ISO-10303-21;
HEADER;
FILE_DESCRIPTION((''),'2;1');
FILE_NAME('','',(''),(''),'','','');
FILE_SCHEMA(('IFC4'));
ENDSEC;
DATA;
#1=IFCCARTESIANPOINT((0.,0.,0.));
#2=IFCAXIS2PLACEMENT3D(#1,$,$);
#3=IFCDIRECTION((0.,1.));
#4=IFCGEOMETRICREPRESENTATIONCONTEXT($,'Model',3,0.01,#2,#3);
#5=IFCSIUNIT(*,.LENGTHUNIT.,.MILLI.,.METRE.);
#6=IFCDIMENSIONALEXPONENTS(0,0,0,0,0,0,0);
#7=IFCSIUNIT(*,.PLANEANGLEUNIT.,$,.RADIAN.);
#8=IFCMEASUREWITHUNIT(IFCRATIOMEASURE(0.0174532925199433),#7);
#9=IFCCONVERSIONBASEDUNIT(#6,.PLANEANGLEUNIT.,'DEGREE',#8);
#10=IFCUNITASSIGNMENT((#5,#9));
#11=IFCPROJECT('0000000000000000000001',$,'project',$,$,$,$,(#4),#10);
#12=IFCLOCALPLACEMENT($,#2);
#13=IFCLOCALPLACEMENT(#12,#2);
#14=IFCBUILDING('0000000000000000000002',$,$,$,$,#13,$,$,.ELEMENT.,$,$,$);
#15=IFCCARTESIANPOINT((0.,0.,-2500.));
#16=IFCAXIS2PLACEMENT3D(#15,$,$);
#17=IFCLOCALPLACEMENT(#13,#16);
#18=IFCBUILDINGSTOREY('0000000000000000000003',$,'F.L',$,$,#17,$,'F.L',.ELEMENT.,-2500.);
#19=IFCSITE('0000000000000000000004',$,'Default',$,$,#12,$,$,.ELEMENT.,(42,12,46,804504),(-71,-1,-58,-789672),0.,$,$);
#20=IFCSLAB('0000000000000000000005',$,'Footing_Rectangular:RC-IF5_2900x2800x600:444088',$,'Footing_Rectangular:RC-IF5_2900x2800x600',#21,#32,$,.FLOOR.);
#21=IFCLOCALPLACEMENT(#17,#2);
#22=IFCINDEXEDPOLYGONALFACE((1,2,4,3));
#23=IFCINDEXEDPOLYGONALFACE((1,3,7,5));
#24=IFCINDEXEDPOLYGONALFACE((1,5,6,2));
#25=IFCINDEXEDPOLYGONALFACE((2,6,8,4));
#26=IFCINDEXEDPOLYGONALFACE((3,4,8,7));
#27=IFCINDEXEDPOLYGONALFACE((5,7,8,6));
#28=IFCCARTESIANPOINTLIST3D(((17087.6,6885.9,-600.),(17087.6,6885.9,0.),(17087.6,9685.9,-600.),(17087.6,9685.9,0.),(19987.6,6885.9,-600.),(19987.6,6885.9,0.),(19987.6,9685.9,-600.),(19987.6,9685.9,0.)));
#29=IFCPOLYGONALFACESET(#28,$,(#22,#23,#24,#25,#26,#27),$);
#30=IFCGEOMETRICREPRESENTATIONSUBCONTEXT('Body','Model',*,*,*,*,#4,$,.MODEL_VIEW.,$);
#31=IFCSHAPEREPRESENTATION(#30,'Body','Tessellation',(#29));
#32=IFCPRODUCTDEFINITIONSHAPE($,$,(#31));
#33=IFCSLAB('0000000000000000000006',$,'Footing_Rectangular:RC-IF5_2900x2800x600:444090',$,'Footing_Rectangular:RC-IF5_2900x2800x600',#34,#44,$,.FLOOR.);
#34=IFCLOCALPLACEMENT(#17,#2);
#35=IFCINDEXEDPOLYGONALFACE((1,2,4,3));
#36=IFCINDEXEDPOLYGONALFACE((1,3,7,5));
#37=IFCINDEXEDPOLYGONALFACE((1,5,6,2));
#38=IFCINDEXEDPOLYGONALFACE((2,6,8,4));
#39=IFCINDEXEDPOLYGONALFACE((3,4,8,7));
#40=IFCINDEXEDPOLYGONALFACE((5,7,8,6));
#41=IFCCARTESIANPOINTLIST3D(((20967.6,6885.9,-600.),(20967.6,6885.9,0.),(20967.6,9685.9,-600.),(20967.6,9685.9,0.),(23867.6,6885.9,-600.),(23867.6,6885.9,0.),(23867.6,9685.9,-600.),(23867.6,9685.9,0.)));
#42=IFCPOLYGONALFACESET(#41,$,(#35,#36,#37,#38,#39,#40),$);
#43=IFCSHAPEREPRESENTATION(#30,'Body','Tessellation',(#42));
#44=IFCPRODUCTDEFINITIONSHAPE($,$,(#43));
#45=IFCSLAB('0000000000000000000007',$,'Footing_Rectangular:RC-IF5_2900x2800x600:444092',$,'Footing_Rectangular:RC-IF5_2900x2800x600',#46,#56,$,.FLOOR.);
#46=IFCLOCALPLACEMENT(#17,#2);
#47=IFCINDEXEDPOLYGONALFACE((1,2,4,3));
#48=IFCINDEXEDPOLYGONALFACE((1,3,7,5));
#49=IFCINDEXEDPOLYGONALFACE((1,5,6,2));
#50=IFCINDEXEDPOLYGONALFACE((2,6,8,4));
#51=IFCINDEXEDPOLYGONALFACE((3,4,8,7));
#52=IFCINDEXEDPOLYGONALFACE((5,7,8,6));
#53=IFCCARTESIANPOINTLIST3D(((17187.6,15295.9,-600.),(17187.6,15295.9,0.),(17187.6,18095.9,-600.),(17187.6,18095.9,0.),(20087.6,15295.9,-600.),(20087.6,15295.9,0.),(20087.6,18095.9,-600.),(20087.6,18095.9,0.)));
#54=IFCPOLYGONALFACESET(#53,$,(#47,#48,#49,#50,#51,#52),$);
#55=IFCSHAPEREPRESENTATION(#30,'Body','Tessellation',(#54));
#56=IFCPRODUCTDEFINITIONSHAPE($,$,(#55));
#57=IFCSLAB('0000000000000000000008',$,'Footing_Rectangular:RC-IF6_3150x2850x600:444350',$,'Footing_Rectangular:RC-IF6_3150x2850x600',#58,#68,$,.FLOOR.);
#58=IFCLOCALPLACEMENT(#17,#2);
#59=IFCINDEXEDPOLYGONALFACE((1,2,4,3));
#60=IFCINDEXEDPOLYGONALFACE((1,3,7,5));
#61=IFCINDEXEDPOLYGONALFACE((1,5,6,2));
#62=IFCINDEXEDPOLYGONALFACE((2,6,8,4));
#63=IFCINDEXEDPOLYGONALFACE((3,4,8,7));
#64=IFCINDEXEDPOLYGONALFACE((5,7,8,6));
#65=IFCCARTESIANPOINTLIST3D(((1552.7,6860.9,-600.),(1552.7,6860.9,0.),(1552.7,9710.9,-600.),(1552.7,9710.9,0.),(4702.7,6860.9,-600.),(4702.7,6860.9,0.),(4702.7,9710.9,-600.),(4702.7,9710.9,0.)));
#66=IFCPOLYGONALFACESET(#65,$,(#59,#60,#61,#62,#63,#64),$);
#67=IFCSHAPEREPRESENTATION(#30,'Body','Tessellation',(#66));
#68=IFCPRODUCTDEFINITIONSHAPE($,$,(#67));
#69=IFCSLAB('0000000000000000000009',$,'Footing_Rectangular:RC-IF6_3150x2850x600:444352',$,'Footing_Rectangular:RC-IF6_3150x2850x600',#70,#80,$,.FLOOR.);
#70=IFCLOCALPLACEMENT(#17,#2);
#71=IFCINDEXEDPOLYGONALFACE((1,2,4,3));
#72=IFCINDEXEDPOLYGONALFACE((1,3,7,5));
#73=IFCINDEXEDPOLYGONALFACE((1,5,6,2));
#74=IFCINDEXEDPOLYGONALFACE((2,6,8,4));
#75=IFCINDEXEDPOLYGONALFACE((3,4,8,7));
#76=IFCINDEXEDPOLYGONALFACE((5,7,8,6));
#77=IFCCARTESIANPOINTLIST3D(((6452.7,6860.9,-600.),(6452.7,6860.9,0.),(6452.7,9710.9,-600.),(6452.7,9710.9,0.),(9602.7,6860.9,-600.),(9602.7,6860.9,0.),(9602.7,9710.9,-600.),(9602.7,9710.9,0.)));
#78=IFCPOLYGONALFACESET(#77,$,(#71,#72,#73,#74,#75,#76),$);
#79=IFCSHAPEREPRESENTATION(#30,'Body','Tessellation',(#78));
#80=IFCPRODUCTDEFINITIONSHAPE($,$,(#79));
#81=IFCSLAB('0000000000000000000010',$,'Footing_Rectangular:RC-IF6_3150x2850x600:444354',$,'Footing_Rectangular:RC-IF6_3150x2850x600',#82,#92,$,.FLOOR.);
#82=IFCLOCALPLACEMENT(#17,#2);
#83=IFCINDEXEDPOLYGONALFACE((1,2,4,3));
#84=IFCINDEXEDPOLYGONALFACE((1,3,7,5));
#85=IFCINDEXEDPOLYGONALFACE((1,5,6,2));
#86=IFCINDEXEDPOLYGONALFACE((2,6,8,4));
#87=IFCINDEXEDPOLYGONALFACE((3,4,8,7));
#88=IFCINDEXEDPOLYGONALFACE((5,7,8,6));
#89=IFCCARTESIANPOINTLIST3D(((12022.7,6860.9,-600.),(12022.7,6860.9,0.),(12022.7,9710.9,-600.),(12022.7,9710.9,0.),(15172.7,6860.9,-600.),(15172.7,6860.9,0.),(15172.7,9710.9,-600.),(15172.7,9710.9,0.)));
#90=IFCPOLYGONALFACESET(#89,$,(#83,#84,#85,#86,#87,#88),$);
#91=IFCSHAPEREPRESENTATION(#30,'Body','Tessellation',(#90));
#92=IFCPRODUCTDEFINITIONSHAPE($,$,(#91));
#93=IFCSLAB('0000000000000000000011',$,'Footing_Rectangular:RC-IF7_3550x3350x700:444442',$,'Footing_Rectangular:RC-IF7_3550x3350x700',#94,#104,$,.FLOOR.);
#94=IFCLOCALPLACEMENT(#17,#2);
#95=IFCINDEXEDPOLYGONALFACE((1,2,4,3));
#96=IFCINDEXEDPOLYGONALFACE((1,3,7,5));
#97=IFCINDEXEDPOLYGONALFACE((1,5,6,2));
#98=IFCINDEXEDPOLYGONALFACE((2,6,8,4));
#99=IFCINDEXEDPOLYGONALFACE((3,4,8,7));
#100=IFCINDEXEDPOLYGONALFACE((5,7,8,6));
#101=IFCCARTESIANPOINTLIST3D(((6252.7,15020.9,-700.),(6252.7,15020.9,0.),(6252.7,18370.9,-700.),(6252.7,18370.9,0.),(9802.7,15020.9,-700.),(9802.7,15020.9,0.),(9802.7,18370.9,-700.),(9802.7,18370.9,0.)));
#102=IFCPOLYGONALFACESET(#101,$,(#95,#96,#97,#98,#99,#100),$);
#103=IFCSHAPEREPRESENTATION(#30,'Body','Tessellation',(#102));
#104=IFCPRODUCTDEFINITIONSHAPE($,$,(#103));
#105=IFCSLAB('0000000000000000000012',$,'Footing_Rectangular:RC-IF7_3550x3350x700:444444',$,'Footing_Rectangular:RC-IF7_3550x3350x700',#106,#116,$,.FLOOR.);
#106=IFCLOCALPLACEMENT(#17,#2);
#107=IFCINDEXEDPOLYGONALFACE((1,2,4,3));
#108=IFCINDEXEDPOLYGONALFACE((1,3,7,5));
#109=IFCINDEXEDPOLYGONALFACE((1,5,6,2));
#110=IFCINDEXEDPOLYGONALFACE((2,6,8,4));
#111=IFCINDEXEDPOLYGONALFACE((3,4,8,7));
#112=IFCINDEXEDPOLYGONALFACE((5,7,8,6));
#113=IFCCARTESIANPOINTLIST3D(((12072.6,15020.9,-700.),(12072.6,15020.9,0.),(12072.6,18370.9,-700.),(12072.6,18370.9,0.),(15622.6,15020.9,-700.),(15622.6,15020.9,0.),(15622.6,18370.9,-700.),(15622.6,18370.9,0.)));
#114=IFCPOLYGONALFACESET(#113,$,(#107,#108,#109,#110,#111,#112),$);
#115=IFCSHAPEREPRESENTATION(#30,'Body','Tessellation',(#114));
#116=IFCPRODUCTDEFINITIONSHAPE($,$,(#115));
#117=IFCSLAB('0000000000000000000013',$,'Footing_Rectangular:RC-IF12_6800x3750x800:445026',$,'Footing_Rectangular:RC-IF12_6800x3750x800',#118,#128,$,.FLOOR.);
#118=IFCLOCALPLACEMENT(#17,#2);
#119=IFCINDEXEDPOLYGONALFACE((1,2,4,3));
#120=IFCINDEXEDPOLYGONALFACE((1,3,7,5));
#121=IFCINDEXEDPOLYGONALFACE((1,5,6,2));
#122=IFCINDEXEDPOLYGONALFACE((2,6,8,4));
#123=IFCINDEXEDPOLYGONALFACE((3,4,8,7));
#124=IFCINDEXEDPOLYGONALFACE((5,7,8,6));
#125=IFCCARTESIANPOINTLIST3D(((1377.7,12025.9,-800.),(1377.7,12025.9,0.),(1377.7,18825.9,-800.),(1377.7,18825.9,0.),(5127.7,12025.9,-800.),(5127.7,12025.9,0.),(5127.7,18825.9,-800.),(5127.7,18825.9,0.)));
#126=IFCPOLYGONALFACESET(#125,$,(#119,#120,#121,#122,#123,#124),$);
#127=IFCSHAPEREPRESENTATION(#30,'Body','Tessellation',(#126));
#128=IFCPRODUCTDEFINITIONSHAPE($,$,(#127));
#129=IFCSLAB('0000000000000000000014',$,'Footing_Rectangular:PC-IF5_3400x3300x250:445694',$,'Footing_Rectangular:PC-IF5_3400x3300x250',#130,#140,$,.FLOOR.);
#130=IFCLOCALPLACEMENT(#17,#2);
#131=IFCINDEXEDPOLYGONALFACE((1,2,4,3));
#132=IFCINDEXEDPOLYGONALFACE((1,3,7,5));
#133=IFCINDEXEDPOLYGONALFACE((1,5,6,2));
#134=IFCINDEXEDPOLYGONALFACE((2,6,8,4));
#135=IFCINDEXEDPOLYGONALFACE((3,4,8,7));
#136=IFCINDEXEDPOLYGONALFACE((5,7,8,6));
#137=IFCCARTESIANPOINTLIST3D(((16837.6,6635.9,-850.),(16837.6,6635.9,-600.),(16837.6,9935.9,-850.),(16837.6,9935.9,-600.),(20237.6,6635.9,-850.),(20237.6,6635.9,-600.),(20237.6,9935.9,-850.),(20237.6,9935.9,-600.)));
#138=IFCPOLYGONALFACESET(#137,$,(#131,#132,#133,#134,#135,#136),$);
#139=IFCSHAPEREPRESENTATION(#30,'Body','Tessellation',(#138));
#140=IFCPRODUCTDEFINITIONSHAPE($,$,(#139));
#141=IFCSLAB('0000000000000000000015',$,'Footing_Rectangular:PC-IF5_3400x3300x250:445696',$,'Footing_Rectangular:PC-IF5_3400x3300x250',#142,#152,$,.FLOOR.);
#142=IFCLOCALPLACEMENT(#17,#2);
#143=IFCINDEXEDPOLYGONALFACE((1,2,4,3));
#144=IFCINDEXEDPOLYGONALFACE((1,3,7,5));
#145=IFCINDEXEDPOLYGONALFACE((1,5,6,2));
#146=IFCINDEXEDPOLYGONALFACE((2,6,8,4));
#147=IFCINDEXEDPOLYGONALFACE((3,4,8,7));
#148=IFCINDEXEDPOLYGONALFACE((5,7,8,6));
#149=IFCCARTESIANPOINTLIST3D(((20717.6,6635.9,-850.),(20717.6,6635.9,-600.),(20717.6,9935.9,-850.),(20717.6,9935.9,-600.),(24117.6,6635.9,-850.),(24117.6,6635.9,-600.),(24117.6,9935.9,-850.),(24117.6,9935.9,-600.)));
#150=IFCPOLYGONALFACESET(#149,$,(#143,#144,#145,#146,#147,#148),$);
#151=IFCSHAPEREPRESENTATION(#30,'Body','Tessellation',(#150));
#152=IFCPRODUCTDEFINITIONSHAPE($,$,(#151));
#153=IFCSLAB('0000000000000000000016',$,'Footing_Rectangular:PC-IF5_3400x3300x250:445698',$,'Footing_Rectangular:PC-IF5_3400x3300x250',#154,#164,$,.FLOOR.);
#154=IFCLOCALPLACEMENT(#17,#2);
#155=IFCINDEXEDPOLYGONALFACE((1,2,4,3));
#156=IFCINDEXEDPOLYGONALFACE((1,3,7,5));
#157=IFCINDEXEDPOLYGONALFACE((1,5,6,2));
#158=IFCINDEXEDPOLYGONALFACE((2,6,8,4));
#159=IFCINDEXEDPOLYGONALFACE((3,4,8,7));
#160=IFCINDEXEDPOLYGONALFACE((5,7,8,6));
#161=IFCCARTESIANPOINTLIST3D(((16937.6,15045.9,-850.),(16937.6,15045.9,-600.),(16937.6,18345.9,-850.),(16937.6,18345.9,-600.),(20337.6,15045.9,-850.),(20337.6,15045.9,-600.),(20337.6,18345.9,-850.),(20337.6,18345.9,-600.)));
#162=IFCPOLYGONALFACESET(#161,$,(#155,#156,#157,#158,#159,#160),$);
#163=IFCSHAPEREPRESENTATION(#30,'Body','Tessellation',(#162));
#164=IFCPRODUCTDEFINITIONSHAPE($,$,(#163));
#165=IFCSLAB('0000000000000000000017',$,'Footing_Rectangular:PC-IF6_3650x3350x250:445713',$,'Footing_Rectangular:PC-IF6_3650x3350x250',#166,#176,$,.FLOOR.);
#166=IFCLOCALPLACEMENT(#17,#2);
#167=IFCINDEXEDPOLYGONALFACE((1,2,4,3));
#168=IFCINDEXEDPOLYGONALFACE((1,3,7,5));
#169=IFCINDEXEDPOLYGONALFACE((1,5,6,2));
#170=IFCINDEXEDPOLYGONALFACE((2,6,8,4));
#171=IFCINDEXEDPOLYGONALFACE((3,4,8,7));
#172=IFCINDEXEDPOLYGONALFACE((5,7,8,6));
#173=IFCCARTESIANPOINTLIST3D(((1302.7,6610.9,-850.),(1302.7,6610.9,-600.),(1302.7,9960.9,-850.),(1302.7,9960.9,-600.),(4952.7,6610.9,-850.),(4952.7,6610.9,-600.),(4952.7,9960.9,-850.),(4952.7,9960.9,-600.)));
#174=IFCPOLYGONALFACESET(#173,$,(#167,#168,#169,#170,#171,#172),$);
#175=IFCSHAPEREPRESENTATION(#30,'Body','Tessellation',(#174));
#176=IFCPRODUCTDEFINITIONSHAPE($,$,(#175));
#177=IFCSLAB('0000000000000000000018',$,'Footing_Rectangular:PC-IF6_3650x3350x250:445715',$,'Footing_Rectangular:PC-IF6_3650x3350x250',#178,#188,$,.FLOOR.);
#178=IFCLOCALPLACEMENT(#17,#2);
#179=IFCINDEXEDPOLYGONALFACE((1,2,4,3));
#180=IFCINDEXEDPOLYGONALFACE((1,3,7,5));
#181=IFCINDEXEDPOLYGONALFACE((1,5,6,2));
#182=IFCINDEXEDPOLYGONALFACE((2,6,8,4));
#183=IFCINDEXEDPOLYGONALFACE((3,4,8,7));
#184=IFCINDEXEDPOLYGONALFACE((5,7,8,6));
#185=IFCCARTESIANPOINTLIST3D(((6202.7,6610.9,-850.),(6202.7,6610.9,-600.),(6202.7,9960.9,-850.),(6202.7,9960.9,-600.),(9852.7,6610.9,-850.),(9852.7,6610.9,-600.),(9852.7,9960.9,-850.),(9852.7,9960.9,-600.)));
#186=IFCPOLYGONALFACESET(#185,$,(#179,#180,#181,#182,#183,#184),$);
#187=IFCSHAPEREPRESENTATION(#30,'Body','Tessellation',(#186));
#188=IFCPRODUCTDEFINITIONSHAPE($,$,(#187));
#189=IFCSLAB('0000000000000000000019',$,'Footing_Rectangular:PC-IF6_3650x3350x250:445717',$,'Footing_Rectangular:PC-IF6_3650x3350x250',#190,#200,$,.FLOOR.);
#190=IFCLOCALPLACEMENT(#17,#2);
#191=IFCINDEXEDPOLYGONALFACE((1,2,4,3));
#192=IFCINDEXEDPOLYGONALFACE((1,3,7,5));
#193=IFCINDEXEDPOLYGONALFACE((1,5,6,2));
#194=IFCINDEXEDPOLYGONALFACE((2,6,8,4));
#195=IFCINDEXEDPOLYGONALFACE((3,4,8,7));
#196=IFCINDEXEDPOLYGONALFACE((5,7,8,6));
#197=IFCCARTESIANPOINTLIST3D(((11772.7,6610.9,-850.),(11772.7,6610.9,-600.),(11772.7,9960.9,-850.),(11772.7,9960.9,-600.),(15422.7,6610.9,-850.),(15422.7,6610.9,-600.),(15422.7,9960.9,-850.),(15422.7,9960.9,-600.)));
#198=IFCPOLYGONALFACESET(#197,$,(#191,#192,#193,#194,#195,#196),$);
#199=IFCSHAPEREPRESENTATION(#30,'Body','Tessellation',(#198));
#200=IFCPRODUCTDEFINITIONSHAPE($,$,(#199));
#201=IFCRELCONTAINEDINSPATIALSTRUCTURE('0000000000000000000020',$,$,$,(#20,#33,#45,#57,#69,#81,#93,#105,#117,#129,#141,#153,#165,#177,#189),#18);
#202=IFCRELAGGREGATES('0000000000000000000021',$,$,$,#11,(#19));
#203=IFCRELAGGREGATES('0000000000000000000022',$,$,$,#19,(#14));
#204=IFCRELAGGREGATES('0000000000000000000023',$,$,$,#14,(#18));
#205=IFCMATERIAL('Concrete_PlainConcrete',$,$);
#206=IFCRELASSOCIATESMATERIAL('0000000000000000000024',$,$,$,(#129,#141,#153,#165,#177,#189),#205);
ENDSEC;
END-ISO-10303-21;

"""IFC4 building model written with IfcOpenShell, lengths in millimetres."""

from ifc_helpers import new_model, entity, si_unit, converted_unit, direction, frame, frame_2d, origin, place, context, subcontext, project, spatial, rectangle, extrude, material, element, save


model = new_model("IFC4")

# Units and contexts
model_context = context("Model", 3, precision=0.01, world=origin(), true_north=direction((0.0, 1.0)))
body_context = subcontext(model_context, "Body", "Model", "MODEL_VIEW")
ifc_project = project(units=[si_unit("LENGTHUNIT", "METRE", prefix="MILLI"), converted_unit("PLANEANGLEUNIT", "DEGREE", entity("IfcRatioMeasure", 0.0174532925199433), si_unit("PLANEANGLEUNIT", "RADIAN"), dimensions=[0, 0, 0, 0, 0, 0, 0])], contexts=[model_context])

# Site, building, storey
site_placement = place(None, origin())
site = spatial("IfcSite", under=ifc_project, at=site_placement, Name="Default", CompositionType="ELEMENT", RefLatitude=(42, 12, 46, 804504), RefLongitude=(-71, -1, -58, -789672), RefElevation=0.0)
building_placement = place(site_placement, origin())
building = spatial("IfcBuilding", under=site, at=building_placement, CompositionType="ELEMENT")
storey_placement = place(building_placement, frame((0.0, 0.0, -2500.0)))
storey = spatial("IfcBuildingStorey", under=building, at=storey_placement, Name="F.L", LongName="F.L", CompositionType="ELEMENT", Elevation=-2500.0)

# Slabs
slab_1_placement = place(storey_placement, frame((17087.6, 6885.9, -600.0)))
element("IfcSlab", 1, at=slab_1_placement, inside=storey, Name="Footing_Rectangular:RC-IF5_2900x2800x600:444088", ObjectType="Footing_Rectangular:RC-IF5_2900x2800x600", PredefinedType="FLOOR", context=body_context, shape_type="SweptSolid", body=[
    extrude(rectangle(XDim=2800.0, YDim=2900.0, at=frame_2d((0.0, 0.0), x_axis=(1.0, 0.0))), frame((1450.0, 1400.0, 0.0), z_axis=(0.0, 0.0, 1.0), x_axis=(0.0, 1.0, 0.0)), (0.0, 0.0, 1.0), 600.0),
])
slab_2_placement = place(storey_placement, frame((20967.6, 6885.9, -600.0)))
element("IfcSlab", 2, at=slab_2_placement, inside=storey, Name="Footing_Rectangular:RC-IF5_2900x2800x600:444090", ObjectType="Footing_Rectangular:RC-IF5_2900x2800x600", PredefinedType="FLOOR", context=body_context, shape_type="SweptSolid", body=[
    extrude(rectangle(XDim=2800.0, YDim=2900.0, at=frame_2d((0.0, 0.0), x_axis=(1.0, 0.0))), frame((1450.0, 1400.0, 0.0), z_axis=(0.0, 0.0, 1.0), x_axis=(0.0, -1.0, 0.0)), (0.0, 0.0, 1.0), 600.0),
])
slab_3_placement = place(storey_placement, frame((17187.6, 15295.9, -600.0)))
element("IfcSlab", 3, at=slab_3_placement, inside=storey, Name="Footing_Rectangular:RC-IF5_2900x2800x600:444092", ObjectType="Footing_Rectangular:RC-IF5_2900x2800x600", PredefinedType="FLOOR", context=body_context, shape_type="SweptSolid", body=[
    extrude(rectangle(XDim=2800.0, YDim=2900.0, at=frame_2d((0.0, 0.0), x_axis=(1.0, 0.0))), frame((1450.0, 1400.0, 0.0), z_axis=(0.0, 0.0, 1.0), x_axis=(0.0, 1.0, 0.0)), (0.0, 0.0, 1.0), 600.0),
])
slab_4_placement = place(storey_placement, frame((1552.7, 6860.9, -600.0)))
element("IfcSlab", 4, at=slab_4_placement, inside=storey, Name="Footing_Rectangular:RC-IF6_3150x2850x600:444350", ObjectType="Footing_Rectangular:RC-IF6_3150x2850x600", PredefinedType="FLOOR", context=body_context, shape_type="SweptSolid", body=[
    extrude(rectangle(XDim=2850.0, YDim=3150.0, at=frame_2d((0.0, 0.0), x_axis=(1.0, 0.0))), frame((1575.0, 1425.0, 0.0), z_axis=(0.0, 0.0, 1.0), x_axis=(0.0, 1.0, 0.0)), (0.0, 0.0, 1.0), 600.0),
])
slab_5_placement = place(storey_placement, frame((6452.7, 6860.9, -600.0)))
element("IfcSlab", 5, at=slab_5_placement, inside=storey, Name="Footing_Rectangular:RC-IF6_3150x2850x600:444352", ObjectType="Footing_Rectangular:RC-IF6_3150x2850x600", PredefinedType="FLOOR", context=body_context, shape_type="SweptSolid", body=[
    extrude(rectangle(XDim=2850.0, YDim=3150.0, at=frame_2d((0.0, 0.0), x_axis=(1.0, 0.0))), frame((1575.0, 1425.0, 0.0), z_axis=(0.0, 0.0, 1.0), x_axis=(0.0, 1.0, 0.0)), (0.0, 0.0, 1.0), 600.0),
])
slab_6_placement = place(storey_placement, frame((12022.7, 6860.9, -600.0)))
element("IfcSlab", 6, at=slab_6_placement, inside=storey, Name="Footing_Rectangular:RC-IF6_3150x2850x600:444354", ObjectType="Footing_Rectangular:RC-IF6_3150x2850x600", PredefinedType="FLOOR", context=body_context, shape_type="SweptSolid", body=[
    extrude(rectangle(XDim=2850.0, YDim=3150.0, at=frame_2d((0.0, 0.0), x_axis=(1.0, 0.0))), frame((1575.0, 1425.0, 0.0), z_axis=(0.0, 0.0, 1.0), x_axis=(0.0, 1.0, 0.0)), (0.0, 0.0, 1.0), 600.0),
])
slab_7_placement = place(storey_placement, frame((6252.7, 15020.9, -700.0)))
element("IfcSlab", 7, at=slab_7_placement, inside=storey, Name="Footing_Rectangular:RC-IF7_3550x3350x700:444442", ObjectType="Footing_Rectangular:RC-IF7_3550x3350x700", PredefinedType="FLOOR", context=body_context, shape_type="SweptSolid", body=[
    extrude(rectangle(XDim=3350.0, YDim=3550.0, at=frame_2d((0.0, 0.0), x_axis=(1.0, 0.0))), frame((1775.0, 1675.0, 0.0), z_axis=(0.0, 0.0, 1.0), x_axis=(0.0, 1.0, 0.0)), (0.0, 0.0, 1.0), 700.0),
])
slab_8_placement = place(storey_placement, frame((12072.6, 15020.9, -700.0)))
element("IfcSlab", 8, at=slab_8_placement, inside=storey, Name="Footing_Rectangular:RC-IF7_3550x3350x700:444444", ObjectType="Footing_Rectangular:RC-IF7_3550x3350x700", PredefinedType="FLOOR", context=body_context, shape_type="SweptSolid", body=[
    extrude(rectangle(XDim=3350.0, YDim=3550.0, at=frame_2d((0.0, 0.0), x_axis=(1.0, 0.0))), frame((1775.0, 1675.0, 0.0), z_axis=(0.0, 0.0, 1.0), x_axis=(0.0, 1.0, 0.0)), (0.0, 0.0, 1.0), 700.0),
])
slab_9_placement = place(storey_placement, frame((1377.7, 12025.9, -800.0)))
element("IfcSlab", 9, at=slab_9_placement, inside=storey, Name="Footing_Rectangular:RC-IF12_6800x3750x800:445026", ObjectType="Footing_Rectangular:RC-IF12_6800x3750x800", PredefinedType="FLOOR", context=body_context, shape_type="SweptSolid", body=[
    extrude(rectangle(XDim=3750.0, YDim=6800.0, at=frame_2d((0.0, 0.0), x_axis=(1.0, 0.0))), frame((1875.0, 3400.0, 0.0), z_axis=(0.0, 0.0, 1.0), x_axis=(-1.0, 0.0, 0.0)), (0.0, 0.0, 1.0), 800.0),
])
ifc_material_1 = material(Name="Concrete_PlainConcrete")
slab_10_placement = place(storey_placement, frame((16837.6, 6635.9, -850.0)))
element("IfcSlab", 10, at=slab_10_placement, inside=storey, material=ifc_material_1, Name="Footing_Rectangular:PC-IF5_3400x3300x250:445694", ObjectType="Footing_Rectangular:PC-IF5_3400x3300x250", PredefinedType="FLOOR", context=body_context, shape_type="SweptSolid", body=[
    extrude(rectangle(XDim=3300.0, YDim=3400.0, at=frame_2d((0.0, 0.0), x_axis=(1.0, 0.0))), frame((1700.0, 1650.0, 0.0), z_axis=(0.0, 0.0, 1.0), x_axis=(0.0, 1.0, 0.0)), (0.0, 0.0, 1.0), 250.0),
])
slab_11_placement = place(storey_placement, frame((20717.6, 6635.9, -850.0)))
element("IfcSlab", 11, at=slab_11_placement, inside=storey, material=ifc_material_1, Name="Footing_Rectangular:PC-IF5_3400x3300x250:445696", ObjectType="Footing_Rectangular:PC-IF5_3400x3300x250", PredefinedType="FLOOR", context=body_context, shape_type="SweptSolid", body=[
    extrude(rectangle(XDim=3300.0, YDim=3400.0, at=frame_2d((0.0, 0.0), x_axis=(1.0, 0.0))), frame((1700.0, 1650.0, 0.0), z_axis=(0.0, 0.0, 1.0), x_axis=(0.0, -1.0, 0.0)), (0.0, 0.0, 1.0), 250.0),
])
slab_12_placement = place(storey_placement, frame((16937.6, 15045.9, -850.0)))
element("IfcSlab", 12, at=slab_12_placement, inside=storey, material=ifc_material_1, Name="Footing_Rectangular:PC-IF5_3400x3300x250:445698", ObjectType="Footing_Rectangular:PC-IF5_3400x3300x250", PredefinedType="FLOOR", context=body_context, shape_type="SweptSolid", body=[
    extrude(rectangle(XDim=3300.0, YDim=3400.0, at=frame_2d((0.0, 0.0), x_axis=(1.0, 0.0))), frame((1700.0, 1650.0, 0.0), z_axis=(0.0, 0.0, 1.0), x_axis=(0.0, 1.0, 0.0)), (0.0, 0.0, 1.0), 250.0),
])
slab_13_placement = place(storey_placement, frame((1302.7, 6610.9, -850.0)))
element("IfcSlab", 13, at=slab_13_placement, inside=storey, material=ifc_material_1, Name="Footing_Rectangular:PC-IF6_3650x3350x250:445713", ObjectType="Footing_Rectangular:PC-IF6_3650x3350x250", PredefinedType="FLOOR", context=body_context, shape_type="SweptSolid", body=[
    extrude(rectangle(XDim=3350.0, YDim=3650.0, at=frame_2d((0.0, 0.0), x_axis=(1.0, 0.0))), frame((1825.0, 1675.0, 0.0), z_axis=(0.0, 0.0, 1.0), x_axis=(0.0, 1.0, 0.0)), (0.0, 0.0, 1.0), 250.0),
])
slab_14_placement = place(storey_placement, frame((6202.7, 6610.9, -850.0)))
element("IfcSlab", 14, at=slab_14_placement, inside=storey, material=ifc_material_1, Name="Footing_Rectangular:PC-IF6_3650x3350x250:445715", ObjectType="Footing_Rectangular:PC-IF6_3650x3350x250", PredefinedType="FLOOR", context=body_context, shape_type="SweptSolid", body=[
    extrude(rectangle(XDim=3350.0, YDim=3650.0, at=frame_2d((0.0, 0.0), x_axis=(1.0, 0.0))), frame((1825.0, 1675.0, 0.0), z_axis=(0.0, 0.0, 1.0), x_axis=(0.0, 1.0, 0.0)), (0.0, 0.0, 1.0), 250.0),
])
slab_15_placement = place(storey_placement, frame((11772.7, 6610.9, -850.0)))
element("IfcSlab", 15, at=slab_15_placement, inside=storey, material=ifc_material_1, Name="Footing_Rectangular:PC-IF6_3650x3350x250:445717", ObjectType="Footing_Rectangular:PC-IF6_3650x3350x250", PredefinedType="FLOOR", context=body_context, shape_type="SweptSolid", body=[
    extrude(rectangle(XDim=3350.0, YDim=3650.0, at=frame_2d((0.0, 0.0), x_axis=(1.0, 0.0))), frame((1825.0, 1675.0, 0.0), z_axis=(0.0, 0.0, 1.0), x_axis=(0.0, 1.0, 0.0)), (0.0, 0.0, 1.0), 250.0),
])

save(model, "model.ifc")
